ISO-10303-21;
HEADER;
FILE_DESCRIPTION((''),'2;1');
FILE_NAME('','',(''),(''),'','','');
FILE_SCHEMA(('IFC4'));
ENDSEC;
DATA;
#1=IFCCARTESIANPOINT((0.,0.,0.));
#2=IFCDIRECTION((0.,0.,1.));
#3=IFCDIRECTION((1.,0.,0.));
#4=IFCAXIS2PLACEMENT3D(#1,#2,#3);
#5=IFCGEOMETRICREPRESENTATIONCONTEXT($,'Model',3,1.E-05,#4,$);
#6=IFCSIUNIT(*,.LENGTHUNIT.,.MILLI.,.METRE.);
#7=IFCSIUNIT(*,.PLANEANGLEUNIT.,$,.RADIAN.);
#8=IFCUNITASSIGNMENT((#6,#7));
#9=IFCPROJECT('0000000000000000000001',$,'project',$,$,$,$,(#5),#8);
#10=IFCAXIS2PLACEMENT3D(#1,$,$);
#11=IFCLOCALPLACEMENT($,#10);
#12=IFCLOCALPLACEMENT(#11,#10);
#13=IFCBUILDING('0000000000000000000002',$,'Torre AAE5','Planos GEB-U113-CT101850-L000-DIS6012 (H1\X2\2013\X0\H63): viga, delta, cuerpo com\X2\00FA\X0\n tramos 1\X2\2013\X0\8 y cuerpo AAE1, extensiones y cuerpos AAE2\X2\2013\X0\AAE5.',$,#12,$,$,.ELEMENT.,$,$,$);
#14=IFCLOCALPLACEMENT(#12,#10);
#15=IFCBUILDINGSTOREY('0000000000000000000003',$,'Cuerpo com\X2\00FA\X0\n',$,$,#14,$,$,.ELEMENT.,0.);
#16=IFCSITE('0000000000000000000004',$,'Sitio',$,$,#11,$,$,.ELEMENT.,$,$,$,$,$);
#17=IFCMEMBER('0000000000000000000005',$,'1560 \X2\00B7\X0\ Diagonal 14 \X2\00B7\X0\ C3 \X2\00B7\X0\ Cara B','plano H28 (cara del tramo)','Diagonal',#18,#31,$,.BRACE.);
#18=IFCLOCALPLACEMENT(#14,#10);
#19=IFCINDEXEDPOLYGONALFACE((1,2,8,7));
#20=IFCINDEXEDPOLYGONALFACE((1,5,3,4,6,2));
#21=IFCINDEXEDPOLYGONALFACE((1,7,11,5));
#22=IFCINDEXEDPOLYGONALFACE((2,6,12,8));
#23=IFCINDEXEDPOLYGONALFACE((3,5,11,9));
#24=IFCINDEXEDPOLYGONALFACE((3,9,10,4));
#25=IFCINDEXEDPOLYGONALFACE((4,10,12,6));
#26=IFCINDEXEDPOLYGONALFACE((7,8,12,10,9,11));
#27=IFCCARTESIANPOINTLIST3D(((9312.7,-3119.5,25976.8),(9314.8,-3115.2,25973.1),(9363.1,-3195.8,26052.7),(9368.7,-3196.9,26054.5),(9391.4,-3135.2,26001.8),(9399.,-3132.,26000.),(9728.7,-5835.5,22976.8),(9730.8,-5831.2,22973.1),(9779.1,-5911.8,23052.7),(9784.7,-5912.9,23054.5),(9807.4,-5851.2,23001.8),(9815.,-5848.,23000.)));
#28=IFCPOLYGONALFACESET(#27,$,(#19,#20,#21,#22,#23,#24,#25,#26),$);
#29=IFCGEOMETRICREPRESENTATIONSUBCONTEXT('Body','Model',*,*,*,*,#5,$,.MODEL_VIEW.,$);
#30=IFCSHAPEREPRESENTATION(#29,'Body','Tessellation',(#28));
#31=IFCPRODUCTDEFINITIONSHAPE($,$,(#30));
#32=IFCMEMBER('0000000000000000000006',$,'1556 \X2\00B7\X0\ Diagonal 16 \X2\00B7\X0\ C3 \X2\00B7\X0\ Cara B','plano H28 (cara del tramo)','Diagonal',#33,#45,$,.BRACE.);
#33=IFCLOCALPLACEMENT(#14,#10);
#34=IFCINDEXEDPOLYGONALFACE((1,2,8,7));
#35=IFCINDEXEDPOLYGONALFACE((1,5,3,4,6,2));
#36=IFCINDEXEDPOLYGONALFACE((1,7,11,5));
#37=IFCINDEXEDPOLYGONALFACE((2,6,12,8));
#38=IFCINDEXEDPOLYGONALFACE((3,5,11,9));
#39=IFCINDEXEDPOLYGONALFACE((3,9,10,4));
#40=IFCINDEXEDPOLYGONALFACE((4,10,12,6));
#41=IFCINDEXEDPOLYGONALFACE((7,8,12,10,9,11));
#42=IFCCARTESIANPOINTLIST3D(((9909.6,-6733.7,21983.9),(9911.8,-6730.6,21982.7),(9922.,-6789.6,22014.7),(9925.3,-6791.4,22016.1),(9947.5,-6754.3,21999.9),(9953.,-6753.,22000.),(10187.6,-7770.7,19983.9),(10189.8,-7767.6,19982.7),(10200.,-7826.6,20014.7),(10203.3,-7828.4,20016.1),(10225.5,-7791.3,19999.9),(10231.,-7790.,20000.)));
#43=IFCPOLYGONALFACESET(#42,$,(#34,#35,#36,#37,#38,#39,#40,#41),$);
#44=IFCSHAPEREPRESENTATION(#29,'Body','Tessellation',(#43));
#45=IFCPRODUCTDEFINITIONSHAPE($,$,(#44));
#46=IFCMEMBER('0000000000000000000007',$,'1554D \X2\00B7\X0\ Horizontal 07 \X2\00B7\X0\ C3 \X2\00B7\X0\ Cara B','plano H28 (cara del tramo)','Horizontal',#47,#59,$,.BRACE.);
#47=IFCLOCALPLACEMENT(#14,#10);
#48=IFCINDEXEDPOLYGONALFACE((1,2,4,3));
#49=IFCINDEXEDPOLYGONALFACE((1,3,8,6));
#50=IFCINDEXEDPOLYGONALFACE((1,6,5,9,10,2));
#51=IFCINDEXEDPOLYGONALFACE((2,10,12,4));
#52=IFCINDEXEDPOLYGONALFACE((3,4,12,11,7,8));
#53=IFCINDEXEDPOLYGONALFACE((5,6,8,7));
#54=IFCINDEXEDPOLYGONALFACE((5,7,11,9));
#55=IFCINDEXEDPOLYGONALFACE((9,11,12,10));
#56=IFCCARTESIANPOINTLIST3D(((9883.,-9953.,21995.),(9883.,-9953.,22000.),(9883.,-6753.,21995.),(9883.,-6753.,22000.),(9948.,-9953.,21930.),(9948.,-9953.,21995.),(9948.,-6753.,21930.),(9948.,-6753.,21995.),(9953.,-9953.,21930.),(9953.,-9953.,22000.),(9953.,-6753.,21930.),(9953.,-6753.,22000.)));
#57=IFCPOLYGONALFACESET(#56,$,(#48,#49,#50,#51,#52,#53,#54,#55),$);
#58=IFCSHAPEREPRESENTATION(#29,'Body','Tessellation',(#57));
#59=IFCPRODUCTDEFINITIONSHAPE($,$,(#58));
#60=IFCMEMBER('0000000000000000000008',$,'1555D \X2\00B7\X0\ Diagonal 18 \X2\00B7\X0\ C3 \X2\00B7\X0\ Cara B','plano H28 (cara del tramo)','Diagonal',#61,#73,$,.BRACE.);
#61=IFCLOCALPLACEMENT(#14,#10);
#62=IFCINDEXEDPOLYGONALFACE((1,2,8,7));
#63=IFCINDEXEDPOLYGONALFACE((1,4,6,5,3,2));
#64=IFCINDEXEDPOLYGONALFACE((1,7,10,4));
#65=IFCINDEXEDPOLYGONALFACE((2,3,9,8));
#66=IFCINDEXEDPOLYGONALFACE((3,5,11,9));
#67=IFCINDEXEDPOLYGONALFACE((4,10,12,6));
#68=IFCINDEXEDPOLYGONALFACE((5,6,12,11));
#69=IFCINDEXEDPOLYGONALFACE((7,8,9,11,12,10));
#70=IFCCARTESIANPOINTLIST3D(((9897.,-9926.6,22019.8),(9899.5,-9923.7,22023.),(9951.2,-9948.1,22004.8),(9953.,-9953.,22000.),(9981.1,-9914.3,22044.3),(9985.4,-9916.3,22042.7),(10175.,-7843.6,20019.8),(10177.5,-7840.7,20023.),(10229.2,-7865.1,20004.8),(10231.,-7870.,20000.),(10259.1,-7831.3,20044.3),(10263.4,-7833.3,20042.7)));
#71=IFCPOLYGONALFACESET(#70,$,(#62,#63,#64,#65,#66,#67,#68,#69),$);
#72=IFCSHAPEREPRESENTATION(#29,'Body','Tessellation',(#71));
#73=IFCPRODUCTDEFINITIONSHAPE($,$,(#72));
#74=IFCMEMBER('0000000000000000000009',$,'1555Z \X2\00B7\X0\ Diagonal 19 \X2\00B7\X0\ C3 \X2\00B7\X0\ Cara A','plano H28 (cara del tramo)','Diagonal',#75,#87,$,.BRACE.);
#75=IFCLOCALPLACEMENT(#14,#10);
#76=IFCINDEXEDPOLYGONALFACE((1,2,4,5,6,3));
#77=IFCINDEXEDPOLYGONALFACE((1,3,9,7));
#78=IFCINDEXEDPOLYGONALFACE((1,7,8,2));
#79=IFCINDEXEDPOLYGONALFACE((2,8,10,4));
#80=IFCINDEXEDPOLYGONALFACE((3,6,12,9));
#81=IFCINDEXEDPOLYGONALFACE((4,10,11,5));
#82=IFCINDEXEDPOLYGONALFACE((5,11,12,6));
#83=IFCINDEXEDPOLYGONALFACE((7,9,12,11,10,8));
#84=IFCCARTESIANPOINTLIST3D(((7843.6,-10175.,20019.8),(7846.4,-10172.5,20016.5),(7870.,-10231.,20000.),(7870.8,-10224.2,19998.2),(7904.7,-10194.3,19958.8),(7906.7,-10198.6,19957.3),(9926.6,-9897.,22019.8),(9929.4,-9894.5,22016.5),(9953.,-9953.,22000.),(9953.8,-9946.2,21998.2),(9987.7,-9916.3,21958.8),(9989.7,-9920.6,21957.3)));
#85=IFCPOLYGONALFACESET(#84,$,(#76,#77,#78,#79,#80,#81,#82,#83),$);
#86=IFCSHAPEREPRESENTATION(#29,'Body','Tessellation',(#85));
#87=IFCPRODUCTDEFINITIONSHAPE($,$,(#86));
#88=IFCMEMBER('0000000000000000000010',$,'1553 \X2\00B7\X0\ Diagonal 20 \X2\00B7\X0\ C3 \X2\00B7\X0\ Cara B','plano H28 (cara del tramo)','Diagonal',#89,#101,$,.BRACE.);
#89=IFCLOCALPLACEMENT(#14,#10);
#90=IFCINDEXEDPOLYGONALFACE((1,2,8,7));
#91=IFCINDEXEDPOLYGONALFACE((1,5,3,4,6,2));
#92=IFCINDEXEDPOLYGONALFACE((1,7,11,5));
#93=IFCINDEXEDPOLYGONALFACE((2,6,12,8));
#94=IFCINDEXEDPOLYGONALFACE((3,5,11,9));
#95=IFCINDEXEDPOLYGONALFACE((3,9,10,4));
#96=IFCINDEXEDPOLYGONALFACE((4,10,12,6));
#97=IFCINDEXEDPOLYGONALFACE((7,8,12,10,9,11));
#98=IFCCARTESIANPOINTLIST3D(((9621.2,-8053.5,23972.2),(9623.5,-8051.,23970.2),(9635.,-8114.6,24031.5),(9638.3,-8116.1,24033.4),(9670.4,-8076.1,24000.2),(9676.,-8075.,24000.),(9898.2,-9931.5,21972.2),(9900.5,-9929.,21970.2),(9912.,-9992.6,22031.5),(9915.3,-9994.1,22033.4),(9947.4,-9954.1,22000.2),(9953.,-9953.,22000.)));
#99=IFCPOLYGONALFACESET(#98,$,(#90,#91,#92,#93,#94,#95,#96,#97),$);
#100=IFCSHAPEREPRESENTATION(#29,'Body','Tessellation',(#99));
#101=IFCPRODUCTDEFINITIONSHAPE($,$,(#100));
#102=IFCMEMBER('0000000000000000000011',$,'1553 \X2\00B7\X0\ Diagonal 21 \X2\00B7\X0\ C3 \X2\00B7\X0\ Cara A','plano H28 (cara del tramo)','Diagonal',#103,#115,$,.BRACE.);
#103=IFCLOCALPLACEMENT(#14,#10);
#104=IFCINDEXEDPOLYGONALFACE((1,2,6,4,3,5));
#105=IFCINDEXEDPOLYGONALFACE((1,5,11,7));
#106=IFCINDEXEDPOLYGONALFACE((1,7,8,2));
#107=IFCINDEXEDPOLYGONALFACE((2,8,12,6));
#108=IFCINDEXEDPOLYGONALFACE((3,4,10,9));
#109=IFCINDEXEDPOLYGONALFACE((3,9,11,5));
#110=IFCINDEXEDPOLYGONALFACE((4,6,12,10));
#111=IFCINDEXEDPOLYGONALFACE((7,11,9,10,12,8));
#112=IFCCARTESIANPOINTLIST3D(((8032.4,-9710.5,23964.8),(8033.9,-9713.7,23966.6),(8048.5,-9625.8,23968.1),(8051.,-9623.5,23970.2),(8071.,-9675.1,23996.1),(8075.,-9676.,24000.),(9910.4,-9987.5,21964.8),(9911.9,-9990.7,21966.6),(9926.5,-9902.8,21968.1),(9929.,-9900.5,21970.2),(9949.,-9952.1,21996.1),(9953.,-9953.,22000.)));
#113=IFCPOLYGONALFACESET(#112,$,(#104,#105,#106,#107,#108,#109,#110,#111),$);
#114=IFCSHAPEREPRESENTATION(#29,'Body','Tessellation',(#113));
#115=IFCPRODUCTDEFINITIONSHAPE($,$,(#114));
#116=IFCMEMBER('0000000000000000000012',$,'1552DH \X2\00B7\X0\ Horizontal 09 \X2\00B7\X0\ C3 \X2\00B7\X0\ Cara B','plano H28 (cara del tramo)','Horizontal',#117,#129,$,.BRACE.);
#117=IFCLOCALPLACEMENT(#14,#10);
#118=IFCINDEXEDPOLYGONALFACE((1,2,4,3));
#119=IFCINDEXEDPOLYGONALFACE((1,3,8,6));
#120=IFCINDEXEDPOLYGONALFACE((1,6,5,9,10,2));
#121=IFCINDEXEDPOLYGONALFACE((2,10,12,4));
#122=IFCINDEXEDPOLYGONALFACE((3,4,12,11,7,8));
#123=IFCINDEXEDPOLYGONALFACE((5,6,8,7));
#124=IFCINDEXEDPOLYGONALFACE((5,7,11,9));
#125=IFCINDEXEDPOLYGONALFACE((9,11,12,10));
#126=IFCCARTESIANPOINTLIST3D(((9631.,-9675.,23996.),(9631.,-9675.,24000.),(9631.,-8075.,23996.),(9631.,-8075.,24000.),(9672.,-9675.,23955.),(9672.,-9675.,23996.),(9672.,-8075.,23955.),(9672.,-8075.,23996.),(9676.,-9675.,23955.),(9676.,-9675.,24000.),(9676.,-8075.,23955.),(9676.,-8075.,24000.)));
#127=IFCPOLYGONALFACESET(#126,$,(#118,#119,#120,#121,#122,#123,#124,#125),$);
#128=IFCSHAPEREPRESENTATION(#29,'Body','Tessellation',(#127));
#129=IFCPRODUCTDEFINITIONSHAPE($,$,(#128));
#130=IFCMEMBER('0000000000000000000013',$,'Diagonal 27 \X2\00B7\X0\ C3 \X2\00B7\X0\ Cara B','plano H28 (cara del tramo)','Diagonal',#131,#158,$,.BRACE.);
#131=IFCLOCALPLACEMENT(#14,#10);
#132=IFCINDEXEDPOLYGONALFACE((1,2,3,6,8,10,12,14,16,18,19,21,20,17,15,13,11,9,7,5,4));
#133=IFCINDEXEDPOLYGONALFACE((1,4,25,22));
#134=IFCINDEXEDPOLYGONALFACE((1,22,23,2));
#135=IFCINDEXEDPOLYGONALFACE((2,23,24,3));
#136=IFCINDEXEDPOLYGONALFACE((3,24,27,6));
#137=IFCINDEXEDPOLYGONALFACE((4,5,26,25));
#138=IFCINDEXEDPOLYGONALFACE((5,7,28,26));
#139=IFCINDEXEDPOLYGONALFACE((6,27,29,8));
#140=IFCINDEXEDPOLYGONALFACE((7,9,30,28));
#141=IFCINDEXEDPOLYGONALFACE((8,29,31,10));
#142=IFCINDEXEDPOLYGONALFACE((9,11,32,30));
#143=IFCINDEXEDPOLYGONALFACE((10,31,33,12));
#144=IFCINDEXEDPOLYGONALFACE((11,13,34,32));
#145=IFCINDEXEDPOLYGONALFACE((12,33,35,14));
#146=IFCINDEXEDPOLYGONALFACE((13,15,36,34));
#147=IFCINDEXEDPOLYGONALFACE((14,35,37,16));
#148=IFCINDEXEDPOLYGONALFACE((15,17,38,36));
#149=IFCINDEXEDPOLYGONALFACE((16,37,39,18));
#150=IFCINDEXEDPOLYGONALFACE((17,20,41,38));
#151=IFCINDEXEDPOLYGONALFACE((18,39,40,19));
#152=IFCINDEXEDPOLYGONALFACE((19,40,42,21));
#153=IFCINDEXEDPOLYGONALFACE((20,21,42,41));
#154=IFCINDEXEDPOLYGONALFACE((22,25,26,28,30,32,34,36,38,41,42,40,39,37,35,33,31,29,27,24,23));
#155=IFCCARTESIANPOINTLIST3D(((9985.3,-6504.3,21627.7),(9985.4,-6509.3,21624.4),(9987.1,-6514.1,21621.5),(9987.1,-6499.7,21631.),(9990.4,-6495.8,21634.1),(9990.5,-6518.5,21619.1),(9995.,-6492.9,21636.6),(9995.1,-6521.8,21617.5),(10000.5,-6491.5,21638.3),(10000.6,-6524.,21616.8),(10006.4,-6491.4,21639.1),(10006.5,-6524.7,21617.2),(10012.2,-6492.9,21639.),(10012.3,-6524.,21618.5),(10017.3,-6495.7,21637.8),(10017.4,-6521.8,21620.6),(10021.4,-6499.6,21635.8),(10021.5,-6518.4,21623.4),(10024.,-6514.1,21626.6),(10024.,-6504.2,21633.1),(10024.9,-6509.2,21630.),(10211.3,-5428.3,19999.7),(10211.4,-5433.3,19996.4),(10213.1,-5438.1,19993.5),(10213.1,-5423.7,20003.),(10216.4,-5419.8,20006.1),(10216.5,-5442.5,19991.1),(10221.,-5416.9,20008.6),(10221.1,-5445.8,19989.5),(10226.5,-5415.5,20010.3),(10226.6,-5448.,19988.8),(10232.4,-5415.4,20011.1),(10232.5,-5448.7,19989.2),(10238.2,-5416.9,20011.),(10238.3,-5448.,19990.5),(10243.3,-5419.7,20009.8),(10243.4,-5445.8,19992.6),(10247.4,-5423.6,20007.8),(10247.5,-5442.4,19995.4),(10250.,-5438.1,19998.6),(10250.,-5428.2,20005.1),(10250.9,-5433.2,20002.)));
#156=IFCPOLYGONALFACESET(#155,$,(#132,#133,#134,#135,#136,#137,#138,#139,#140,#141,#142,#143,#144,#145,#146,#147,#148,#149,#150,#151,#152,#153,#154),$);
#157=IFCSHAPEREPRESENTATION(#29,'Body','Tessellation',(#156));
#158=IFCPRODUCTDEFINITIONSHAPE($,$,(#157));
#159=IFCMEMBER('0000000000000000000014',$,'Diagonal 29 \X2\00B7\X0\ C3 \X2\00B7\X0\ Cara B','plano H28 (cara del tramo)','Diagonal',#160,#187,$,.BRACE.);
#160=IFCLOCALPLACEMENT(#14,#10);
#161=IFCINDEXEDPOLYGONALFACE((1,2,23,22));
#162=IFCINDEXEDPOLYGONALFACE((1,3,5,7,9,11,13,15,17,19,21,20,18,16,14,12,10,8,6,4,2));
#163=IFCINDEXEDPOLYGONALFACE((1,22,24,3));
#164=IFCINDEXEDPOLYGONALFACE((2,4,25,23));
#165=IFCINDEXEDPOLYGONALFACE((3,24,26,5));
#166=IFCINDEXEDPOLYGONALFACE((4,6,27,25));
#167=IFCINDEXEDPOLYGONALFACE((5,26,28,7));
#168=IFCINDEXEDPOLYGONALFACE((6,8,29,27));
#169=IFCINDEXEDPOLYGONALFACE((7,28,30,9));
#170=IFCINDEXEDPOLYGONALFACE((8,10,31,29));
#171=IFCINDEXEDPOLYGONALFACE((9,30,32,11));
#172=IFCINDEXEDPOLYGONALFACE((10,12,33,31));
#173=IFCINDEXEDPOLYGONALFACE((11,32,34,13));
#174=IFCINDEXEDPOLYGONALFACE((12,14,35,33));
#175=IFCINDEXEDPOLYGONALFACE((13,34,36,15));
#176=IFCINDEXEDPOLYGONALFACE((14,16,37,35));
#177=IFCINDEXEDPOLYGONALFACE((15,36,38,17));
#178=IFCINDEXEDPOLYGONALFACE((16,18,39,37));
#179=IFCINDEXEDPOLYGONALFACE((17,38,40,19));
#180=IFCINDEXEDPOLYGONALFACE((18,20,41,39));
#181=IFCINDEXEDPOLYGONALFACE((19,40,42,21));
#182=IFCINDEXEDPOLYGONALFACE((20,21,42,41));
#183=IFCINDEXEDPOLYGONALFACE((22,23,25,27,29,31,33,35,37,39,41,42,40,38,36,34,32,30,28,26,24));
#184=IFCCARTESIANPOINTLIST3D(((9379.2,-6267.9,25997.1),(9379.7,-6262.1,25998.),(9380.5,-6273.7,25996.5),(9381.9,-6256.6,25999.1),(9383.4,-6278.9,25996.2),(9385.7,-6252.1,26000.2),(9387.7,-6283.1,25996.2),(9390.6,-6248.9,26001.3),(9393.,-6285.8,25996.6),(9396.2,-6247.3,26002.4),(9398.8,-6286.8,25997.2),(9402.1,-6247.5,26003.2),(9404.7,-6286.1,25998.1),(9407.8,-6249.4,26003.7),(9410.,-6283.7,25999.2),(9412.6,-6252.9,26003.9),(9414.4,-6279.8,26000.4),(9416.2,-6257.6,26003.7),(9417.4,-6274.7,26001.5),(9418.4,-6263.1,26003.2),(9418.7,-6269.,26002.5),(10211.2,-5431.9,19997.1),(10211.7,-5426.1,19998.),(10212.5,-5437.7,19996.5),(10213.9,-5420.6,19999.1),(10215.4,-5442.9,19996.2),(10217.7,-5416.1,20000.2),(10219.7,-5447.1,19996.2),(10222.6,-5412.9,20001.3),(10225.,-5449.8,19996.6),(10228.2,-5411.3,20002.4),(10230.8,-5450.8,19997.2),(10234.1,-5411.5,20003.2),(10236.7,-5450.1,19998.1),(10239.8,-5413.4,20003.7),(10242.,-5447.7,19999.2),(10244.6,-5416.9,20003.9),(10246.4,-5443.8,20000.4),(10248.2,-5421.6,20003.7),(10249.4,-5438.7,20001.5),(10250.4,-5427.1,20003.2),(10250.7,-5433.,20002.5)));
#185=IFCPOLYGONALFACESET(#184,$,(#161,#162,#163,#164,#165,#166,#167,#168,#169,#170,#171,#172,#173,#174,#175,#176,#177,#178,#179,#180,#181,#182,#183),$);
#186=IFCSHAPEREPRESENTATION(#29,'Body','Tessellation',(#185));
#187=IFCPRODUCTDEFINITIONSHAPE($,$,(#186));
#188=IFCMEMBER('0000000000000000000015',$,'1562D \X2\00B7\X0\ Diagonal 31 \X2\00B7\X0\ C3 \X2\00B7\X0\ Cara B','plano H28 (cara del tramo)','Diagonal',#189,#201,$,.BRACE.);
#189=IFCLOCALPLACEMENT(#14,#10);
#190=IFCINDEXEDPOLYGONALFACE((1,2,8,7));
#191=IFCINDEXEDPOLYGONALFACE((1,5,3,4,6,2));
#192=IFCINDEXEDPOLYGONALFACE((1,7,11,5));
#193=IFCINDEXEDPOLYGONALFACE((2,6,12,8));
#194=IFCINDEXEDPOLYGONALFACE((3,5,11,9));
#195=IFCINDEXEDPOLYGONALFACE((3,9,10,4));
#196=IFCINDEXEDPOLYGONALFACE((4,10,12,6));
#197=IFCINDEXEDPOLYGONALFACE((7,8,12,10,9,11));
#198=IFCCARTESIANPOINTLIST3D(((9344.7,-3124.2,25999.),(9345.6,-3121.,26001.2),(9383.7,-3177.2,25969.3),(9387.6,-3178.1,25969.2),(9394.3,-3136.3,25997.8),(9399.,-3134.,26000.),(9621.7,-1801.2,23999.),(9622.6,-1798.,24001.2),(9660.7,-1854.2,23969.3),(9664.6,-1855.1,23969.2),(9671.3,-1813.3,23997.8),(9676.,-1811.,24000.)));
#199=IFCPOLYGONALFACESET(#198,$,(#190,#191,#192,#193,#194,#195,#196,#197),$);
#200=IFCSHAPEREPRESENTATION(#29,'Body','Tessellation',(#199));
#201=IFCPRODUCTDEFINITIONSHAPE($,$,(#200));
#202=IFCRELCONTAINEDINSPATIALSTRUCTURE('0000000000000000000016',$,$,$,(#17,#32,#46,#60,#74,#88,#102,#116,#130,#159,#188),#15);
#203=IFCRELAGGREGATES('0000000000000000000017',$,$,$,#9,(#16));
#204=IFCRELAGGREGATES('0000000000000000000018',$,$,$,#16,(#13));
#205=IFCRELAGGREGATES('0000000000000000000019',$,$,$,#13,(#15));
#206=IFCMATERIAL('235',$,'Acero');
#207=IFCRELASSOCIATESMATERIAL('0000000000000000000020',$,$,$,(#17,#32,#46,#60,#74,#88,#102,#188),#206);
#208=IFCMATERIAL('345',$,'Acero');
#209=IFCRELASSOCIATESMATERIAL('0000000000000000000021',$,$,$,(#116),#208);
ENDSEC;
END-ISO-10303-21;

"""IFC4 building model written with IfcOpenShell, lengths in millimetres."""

from ifc_helpers import new_model, si_unit, frame, frame_2d, origin, origin_with_axes, place, context, subcontext, project, spatial, circle, l_section, extrude, material, element, save


model = new_model("IFC4")

# Units and contexts
model_context = context("Model", 3, precision=1e-05, world=origin_with_axes())
body_context = subcontext(model_context, "Body", "Model", "MODEL_VIEW")
ifc_project = project(units=[si_unit("LENGTHUNIT", "METRE", prefix="MILLI"), si_unit("PLANEANGLEUNIT", "RADIAN")], contexts=[model_context])

# Site, building, storey
site_placement = place(None, origin())
site = spatial("IfcSite", under=ifc_project, at=site_placement, Name="Sitio", CompositionType="ELEMENT")
building_placement = place(site_placement, origin())
building = spatial("IfcBuilding", under=site, at=building_placement, Name="Torre AAE5", Description="Planos GEB-U113-CT101850-L000-DIS6012 (H1–H63): viga, delta, cuerpo común tramos 1–8 y cuerpo AAE1, extensiones y cuerpos AAE2–AAE5.", CompositionType="ELEMENT")
storey_placement = place(building_placement, origin())
storey = spatial("IfcBuildingStorey", under=building, at=storey_placement, Name="Cuerpo común", CompositionType="ELEMENT", Elevation=0.0)

# Members
ifc_material_1 = material(Name="235", Category="Acero")
ifc_material_2 = material(Name="345", Category="Acero")
member_1_placement = place(storey_placement, frame((9815.0, -5848.0, 23000.0), z_axis=(-0.102258, 0.667628, 0.737439), x_axis=(-0.935984, 0.186465, -0.298603)))
element("IfcMember", 1, at=member_1_placement, inside=storey, material=ifc_material_1, Name="1560 · Diagonal 14 · C3 · Cara B", Description="plano H28 (cara del tramo)", ObjectType="Diagonal", PredefinedType="BRACE", context=body_context, shape_type="SweptSolid", body=[
    extrude(l_section(Depth=90.0, Width=90.0, Thickness=6.0, at=frame_2d((45.0, 45.0))), None, (0.0, 0.0, 1.0), 4068.1),
])
member_2_placement = place(storey_placement, frame((10231.0, -7790.0, 20000.0), z_axis=(-0.12247, 0.456839, 0.881078), x_axis=(-0.823752, 0.448371, -0.346982)))
element("IfcMember", 2, at=member_2_placement, inside=storey, material=ifc_material_1, Name="1556 · Diagonal 16 · C3 · Cara B", Description="plano H28 (cara del tramo)", ObjectType="Diagonal", PredefinedType="BRACE", context=body_context, shape_type="SweptSolid", body=[
    extrude(l_section(Depth=50.0, Width=50.0, Thickness=4.0, at=frame_2d((25.0, 25.0))), None, (0.0, 0.0, 1.0), 2269.9),
])
member_3_placement = place(storey_placement, frame((9953.0, -6753.0, 22000.0), z_axis=(0.0, -1.0, 0.0), x_axis=(-1.0, 0.0, 0.0)))
element("IfcMember", 3, at=member_3_placement, inside=storey, material=ifc_material_1, Name="1554D · Horizontal 07 · C3 · Cara B", Description="plano H28 (cara del tramo)", ObjectType="Horizontal", PredefinedType="BRACE", context=body_context, shape_type="SweptSolid", body=[
    extrude(l_section(Depth=70.0, Width=70.0, Thickness=5.0, at=frame_2d((35.0, 35.0))), None, (0.0, 0.0, 1.0), 3200.0),
])
for number, where, z_axis, x_axis, name in (
    (4, (9953.0, -9953.0, 22000.0), (0.095827, 0.718012, -0.689402), (-0.86146, 0.406815, 0.303955), "1555D · Diagonal 18 · C3 · Cara B"),
    (5, (9953.0, -9953.0, 22000.0), (-0.718012, -0.095827, -0.689402), (-0.406815, 0.86146, 0.303955), "1555Z · Diagonal 19 · C3 · Cara A"),
):
    element("IfcMember", number, at=place(storey_placement, frame(where, z_axis=z_axis, x_axis=x_axis)), inside=storey, material=ifc_material_1, Name=name, Description="plano H28 (cara del tramo)", ObjectType="Diagonal", PredefinedType="BRACE", context=body_context, shape_type="SweptSolid", body=[
        extrude(l_section(Depth=65.0, Width=65.0, Thickness=5.0, at=frame_2d((32.5, 32.5))), None, (0.0, 0.0, 1.0), 2901.1),
    ])
for number, where, z_axis, x_axis, name in (
    (6, (9953.0, -9953.0, 22000.0), (-0.100455, 0.68106, 0.725304), (-0.807986, 0.369544, -0.458908), "1553 · Diagonal 20 · C3 · Cara B"),
    (7, (9953.0, -9953.0, 22000.0), (-0.68106, 0.100455, 0.725304), (-0.369544, 0.807986, -0.458908), "1553 · Diagonal 21 · C3 · Cara A"),
):
    element("IfcMember", number, at=place(storey_placement, frame(where, z_axis=z_axis, x_axis=x_axis)), inside=storey, material=ifc_material_1, Name=name, Description="plano H28 (cara del tramo)", ObjectType="Diagonal", PredefinedType="BRACE", context=body_context, shape_type="SweptSolid", body=[
        extrude(l_section(Depth=65.0, Width=65.0, Thickness=4.0, at=frame_2d((32.5, 32.5))), None, (0.0, 0.0, 1.0), 2757.5),
    ])
member_4_placement = place(storey_placement, frame((9676.0, -8075.0, 24000.0), z_axis=(0.0, -1.0, 0.0), x_axis=(-1.0, 0.0, 0.0)))
element("IfcMember", 8, at=member_4_placement, inside=storey, material=ifc_material_2, Name="1552DH · Horizontal 09 · C3 · Cara B", Description="plano H28 (cara del tramo)", ObjectType="Horizontal", PredefinedType="BRACE", context=body_context, shape_type="SweptSolid", body=[
    extrude(l_section(Depth=45.0, Width=45.0, Thickness=4.0, at=frame_2d((22.5, 22.5))), None, (0.0, 0.0, 1.0), 1600.0),
])
member_5_placement = place(storey_placement, frame((10005.0, -6508.0, 21628.0), z_axis=(0.115042, 0.547724, -0.828712), x_axis=(-0.896397, 0.41674, 0.150999)))
element("IfcMember", 9, at=member_5_placement, inside=storey, Name="Diagonal 27 · C3 · Cara B", Description="plano H28 (cara del tramo)", ObjectType="Diagonal", PredefinedType="BRACE", context=body_context, shape_type="SweptSolid", body=[
    extrude(circle(Radius=20.0), None, (0.0, 0.0, 1.0), 1964.5),
])
member_6_placement = place(storey_placement, frame((10231.0, -5431.0, 20000.0), z_axis=(-0.136063, -0.136717, 0.981221), x_axis=(-0.853592, 0.518901, -0.046065)))
element("IfcMember", 10, at=member_6_placement, inside=storey, Name="Diagonal 29 · C3 · Cara B", Description="plano H28 (cara del tramo)", ObjectType="Diagonal", PredefinedType="BRACE", context=body_context, shape_type="SweptSolid", body=[
    extrude(circle(Radius=20.0), None, (0.0, 0.0, 1.0), 6114.8),
])
member_7_placement = place(storey_placement, frame((9676.0, -1811.0, 24000.0), z_axis=(-0.114751, -0.548069, 0.828524), x_axis=(-0.971377, 0.236528, 0.021927)))
element("IfcMember", 11, at=member_7_placement, inside=storey, material=ifc_material_1, Name="1562D · Diagonal 31 · C3 · Cara B", Description="plano H28 (cara del tramo)", ObjectType="Diagonal", PredefinedType="BRACE", context=body_context, shape_type="SweptSolid", body=[
    extrude(l_section(Depth=55.0, Width=55.0, Thickness=4.0, at=frame_2d((27.5, 27.5))), None, (0.0, 0.0, 1.0), 2413.9),
])

save(model, "model.ifc")
